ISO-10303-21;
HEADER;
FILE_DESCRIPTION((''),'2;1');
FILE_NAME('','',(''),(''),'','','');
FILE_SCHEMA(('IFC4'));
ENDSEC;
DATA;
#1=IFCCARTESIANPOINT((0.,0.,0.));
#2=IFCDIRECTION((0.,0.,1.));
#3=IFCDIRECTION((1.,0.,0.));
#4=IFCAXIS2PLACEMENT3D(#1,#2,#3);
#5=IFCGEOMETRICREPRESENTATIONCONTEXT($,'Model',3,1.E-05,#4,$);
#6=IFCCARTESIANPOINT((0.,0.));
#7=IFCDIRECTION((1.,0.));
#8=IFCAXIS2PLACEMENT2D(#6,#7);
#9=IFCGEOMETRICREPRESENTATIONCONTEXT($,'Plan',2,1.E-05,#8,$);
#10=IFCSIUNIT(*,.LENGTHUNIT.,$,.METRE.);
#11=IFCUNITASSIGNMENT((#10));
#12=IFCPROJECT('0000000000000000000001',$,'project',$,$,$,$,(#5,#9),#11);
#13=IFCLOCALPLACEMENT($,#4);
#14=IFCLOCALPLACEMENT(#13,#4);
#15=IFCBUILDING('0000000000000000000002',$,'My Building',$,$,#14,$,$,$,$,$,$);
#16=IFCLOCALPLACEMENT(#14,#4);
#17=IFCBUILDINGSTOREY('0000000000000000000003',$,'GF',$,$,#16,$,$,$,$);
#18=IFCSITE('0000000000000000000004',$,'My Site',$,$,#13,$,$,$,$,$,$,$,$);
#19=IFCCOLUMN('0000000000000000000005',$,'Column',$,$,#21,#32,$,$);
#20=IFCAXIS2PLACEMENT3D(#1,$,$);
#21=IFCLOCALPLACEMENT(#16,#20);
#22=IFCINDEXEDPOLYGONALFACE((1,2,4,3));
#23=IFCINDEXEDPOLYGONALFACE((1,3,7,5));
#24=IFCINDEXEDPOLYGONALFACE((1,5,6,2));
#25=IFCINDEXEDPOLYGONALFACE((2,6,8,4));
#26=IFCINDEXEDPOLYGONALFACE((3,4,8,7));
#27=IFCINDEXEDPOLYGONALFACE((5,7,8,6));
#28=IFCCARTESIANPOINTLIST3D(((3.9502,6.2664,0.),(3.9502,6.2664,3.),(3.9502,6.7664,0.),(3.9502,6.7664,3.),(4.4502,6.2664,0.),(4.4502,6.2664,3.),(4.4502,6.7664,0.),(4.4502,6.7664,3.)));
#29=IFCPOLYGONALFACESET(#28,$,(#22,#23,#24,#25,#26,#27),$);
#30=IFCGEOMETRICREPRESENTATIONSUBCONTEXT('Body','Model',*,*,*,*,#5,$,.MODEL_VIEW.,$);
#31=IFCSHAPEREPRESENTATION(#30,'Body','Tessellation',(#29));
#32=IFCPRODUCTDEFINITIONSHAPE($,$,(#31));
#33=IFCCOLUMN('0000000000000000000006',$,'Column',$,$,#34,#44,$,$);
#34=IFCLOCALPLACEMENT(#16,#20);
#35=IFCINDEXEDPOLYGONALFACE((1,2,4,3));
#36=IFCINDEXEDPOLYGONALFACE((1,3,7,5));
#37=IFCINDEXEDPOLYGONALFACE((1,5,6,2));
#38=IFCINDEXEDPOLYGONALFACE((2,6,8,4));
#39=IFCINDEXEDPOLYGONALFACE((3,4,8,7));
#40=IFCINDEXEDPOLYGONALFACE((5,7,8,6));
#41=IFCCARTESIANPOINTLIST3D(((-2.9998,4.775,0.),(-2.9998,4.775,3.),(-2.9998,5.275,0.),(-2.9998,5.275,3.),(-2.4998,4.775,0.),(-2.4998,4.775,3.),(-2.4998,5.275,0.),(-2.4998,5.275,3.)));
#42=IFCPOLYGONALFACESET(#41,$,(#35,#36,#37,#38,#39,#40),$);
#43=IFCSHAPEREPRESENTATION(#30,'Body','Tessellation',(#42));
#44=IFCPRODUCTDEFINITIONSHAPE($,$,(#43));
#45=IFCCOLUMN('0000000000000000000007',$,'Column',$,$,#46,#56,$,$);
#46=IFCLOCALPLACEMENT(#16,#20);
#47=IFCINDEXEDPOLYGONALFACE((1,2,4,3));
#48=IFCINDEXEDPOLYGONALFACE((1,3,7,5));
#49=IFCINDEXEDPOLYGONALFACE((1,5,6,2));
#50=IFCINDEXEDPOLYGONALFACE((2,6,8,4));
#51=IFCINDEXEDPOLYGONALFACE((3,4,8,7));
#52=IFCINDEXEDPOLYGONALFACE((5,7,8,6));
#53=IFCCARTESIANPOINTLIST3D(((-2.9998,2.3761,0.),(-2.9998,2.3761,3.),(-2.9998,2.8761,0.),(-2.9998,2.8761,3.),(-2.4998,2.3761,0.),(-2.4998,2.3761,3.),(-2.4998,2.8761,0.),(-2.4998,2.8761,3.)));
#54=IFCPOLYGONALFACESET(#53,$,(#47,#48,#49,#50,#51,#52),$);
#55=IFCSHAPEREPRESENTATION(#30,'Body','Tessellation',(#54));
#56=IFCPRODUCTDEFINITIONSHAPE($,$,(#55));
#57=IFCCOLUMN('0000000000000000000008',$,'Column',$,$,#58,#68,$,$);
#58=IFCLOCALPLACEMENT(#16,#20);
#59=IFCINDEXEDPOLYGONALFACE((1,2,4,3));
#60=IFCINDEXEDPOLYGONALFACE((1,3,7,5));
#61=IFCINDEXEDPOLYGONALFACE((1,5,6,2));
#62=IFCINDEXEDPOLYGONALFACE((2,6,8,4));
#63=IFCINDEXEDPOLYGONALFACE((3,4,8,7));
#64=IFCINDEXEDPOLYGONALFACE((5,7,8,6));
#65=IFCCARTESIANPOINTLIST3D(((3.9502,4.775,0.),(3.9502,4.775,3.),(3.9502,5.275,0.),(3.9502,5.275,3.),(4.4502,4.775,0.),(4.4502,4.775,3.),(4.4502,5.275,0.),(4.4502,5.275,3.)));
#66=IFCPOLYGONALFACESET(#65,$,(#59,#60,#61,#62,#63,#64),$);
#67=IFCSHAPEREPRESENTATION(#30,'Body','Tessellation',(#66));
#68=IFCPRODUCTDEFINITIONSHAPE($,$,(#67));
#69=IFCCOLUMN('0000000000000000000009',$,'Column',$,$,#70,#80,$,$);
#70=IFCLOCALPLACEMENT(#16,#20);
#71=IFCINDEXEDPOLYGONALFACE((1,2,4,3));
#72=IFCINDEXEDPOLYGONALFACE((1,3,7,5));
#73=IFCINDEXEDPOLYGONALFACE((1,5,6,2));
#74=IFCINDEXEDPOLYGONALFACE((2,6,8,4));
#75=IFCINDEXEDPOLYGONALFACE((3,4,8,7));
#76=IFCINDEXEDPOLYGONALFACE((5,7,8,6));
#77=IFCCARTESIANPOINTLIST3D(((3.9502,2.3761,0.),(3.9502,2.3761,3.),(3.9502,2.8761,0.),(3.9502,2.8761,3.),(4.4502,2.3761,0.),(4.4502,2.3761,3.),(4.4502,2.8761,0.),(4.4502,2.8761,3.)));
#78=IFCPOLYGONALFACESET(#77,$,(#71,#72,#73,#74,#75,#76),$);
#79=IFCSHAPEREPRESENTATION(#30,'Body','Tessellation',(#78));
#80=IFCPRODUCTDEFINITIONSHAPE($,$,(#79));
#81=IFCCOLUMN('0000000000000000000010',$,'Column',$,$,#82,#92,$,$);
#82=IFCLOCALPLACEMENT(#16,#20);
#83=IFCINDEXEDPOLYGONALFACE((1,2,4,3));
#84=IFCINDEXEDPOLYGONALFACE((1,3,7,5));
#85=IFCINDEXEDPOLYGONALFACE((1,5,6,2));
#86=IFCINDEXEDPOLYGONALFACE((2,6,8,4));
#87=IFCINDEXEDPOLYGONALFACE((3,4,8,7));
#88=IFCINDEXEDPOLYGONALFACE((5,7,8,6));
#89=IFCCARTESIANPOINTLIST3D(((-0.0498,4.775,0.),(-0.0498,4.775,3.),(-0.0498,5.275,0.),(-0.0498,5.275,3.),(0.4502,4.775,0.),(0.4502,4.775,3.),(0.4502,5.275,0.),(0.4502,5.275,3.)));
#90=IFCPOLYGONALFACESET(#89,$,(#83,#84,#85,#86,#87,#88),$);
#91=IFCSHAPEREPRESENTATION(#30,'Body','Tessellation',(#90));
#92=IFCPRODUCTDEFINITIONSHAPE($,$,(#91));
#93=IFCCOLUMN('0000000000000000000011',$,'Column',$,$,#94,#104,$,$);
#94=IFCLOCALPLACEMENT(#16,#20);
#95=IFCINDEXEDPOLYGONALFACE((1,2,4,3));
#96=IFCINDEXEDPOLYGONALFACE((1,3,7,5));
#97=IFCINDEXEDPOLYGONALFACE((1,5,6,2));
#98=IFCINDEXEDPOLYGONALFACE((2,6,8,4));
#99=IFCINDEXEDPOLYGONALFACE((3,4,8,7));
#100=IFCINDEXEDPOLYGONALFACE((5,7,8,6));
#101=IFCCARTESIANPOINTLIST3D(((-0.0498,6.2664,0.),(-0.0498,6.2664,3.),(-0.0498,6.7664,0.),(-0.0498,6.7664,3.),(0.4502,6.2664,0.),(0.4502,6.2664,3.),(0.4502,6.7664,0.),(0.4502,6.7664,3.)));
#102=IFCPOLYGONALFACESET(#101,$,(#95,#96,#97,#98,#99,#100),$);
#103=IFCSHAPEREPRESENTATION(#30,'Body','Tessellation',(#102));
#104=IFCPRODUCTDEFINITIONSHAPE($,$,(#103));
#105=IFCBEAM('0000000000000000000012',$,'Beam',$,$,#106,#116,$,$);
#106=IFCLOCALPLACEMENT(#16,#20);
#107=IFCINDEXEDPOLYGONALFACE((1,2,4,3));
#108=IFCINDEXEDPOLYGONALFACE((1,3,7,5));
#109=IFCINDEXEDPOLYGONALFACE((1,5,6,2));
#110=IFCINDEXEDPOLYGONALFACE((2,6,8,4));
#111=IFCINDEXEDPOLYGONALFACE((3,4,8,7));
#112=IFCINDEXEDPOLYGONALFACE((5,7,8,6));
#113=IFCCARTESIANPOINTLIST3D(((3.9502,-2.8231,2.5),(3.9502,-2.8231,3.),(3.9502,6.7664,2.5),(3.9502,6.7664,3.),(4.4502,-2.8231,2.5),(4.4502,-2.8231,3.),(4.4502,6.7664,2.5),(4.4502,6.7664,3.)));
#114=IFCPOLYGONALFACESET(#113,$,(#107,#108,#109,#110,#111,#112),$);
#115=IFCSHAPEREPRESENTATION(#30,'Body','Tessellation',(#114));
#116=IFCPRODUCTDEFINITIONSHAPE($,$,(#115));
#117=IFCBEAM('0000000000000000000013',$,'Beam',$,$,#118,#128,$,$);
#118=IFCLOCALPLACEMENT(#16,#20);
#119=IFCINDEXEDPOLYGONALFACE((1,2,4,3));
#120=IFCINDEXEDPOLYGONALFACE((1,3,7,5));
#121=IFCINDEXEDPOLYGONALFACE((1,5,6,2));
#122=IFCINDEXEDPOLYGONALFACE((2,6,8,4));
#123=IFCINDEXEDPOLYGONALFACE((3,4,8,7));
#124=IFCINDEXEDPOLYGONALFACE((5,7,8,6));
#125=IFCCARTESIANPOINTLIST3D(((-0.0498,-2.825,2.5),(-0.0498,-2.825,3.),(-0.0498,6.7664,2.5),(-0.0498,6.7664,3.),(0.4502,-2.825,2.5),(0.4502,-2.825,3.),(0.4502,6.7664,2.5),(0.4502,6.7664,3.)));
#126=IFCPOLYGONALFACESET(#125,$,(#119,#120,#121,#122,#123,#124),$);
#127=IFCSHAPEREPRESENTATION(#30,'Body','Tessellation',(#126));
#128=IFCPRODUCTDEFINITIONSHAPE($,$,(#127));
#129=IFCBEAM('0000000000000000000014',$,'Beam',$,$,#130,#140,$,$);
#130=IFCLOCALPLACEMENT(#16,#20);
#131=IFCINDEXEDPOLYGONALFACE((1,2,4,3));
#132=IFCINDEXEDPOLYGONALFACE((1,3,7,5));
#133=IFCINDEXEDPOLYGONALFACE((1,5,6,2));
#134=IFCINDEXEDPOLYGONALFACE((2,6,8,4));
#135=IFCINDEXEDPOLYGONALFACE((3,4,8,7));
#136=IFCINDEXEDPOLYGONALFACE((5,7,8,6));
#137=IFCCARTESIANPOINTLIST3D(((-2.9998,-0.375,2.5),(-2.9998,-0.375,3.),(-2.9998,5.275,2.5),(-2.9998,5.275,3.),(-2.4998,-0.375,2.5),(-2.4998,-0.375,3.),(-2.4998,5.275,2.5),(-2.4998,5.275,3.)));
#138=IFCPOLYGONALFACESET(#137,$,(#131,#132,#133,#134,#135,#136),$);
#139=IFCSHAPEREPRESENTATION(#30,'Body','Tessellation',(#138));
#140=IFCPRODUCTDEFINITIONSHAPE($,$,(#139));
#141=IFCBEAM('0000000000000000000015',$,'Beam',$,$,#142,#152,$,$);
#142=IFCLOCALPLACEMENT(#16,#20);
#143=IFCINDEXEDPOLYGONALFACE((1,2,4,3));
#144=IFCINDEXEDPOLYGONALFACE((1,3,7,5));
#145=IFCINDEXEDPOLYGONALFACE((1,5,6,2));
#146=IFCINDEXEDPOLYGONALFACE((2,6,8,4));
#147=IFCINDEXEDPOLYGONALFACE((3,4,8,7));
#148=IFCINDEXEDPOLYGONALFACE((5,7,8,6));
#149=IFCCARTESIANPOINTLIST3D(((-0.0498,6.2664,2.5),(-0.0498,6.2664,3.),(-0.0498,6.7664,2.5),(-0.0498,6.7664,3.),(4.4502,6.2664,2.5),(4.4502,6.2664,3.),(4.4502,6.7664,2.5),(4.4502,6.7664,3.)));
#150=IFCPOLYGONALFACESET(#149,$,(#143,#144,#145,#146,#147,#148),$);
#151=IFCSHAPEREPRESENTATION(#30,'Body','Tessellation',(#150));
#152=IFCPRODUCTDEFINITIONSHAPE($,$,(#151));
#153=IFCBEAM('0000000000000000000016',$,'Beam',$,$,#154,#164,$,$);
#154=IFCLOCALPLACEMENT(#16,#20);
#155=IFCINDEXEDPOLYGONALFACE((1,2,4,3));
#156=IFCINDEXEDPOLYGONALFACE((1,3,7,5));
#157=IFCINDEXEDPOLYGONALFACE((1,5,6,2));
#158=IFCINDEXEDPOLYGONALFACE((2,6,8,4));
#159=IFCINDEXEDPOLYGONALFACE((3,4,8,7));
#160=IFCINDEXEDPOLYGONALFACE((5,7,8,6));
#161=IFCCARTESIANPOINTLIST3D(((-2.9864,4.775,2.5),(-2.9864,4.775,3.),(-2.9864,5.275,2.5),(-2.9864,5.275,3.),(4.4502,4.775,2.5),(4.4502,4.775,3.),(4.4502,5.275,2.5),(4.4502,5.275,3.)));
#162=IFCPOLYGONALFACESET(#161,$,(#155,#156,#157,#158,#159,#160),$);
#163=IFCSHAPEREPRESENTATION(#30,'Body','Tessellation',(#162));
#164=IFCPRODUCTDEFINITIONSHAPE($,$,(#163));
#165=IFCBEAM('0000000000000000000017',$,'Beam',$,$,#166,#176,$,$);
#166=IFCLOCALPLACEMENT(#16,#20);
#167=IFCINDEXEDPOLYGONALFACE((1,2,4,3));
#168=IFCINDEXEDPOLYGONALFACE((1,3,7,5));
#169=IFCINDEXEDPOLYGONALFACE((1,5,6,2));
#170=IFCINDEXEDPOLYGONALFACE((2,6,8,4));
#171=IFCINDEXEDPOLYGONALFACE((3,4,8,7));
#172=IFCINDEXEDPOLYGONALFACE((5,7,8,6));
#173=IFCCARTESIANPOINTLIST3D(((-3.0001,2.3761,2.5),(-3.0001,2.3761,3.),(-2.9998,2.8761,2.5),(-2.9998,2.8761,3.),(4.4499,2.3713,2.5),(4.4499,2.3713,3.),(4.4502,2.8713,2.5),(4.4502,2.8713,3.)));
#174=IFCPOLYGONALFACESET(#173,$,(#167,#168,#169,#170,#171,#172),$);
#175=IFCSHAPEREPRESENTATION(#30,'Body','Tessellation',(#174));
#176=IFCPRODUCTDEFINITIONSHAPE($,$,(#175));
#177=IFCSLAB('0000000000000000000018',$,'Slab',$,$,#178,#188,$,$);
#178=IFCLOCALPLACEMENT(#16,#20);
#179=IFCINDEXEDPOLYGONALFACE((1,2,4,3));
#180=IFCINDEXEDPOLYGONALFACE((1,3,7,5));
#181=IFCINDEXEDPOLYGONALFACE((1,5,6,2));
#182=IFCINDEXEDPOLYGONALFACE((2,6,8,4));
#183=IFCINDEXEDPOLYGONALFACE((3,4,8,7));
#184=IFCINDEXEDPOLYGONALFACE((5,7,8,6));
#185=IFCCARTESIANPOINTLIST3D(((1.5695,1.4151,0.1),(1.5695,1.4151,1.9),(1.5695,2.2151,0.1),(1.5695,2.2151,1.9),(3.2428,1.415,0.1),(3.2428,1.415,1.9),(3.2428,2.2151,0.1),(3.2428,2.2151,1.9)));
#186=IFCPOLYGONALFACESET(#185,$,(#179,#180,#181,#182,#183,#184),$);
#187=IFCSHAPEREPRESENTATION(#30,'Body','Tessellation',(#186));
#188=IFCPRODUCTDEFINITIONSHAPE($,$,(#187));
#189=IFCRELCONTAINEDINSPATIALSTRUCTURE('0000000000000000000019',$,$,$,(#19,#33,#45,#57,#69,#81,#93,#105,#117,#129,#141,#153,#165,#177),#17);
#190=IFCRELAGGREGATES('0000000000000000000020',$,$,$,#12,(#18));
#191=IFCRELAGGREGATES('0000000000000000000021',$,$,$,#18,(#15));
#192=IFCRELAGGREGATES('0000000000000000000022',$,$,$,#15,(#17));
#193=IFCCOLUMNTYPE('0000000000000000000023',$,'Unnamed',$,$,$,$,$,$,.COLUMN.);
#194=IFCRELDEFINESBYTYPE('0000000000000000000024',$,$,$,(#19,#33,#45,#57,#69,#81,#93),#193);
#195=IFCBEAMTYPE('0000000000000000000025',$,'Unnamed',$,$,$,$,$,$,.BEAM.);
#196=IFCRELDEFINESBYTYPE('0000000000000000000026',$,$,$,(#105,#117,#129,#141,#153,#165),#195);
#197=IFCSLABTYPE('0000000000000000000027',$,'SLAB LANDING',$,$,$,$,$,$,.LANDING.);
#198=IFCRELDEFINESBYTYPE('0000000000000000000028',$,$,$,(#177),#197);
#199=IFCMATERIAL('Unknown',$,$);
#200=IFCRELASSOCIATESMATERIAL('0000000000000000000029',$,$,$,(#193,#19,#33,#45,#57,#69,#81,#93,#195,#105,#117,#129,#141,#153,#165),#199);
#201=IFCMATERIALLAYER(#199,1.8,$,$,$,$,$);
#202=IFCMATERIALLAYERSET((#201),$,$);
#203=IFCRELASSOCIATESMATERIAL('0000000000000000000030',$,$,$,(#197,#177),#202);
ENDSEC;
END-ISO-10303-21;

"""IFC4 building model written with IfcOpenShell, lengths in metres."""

from ifc_helpers import new_model, si_unit, frame, origin_with_axes, origin_2d_with_axis, place, context, subcontext, project, spatial, indexed_curve, rectangle, outline, extrude, material, layer, layer_set, layer_usage, material_profile, profile_set, profile_usage, type_object, element, save


model = new_model("IFC4")

# Units and contexts
model_context = context("Model", 3, precision=1e-05, world=origin_with_axes())
plan_context = context("Plan", 2, precision=1e-05, world=origin_2d_with_axis())
body_context_1 = subcontext(model_context, "Body", "Model", "MODEL_VIEW")
ifc_project = project(units=[si_unit("LENGTHUNIT", "METRE")], contexts=[model_context, plan_context])

# Site, building, storey
site_placement = place(None, origin_with_axes())
site = spatial("IfcSite", under=ifc_project, at=site_placement, Name="My Site")
building_placement = place(site_placement, origin_with_axes())
building = spatial("IfcBuilding", under=site, at=building_placement, Name="My Building")
storey_placement = place(building_placement, origin_with_axes())
storey = spatial("IfcBuildingStorey", under=building, at=storey_placement, Name="GF")

# Columns
ifc_material_1 = material(Name="Unknown")
ifc_material_profile_1 = material_profile(ifc_material_1, rectangle(XDim=0.5, YDim=0.5))
ifc_profile_set_1 = profile_set([ifc_material_profile_1])
ifc_profile_usage_1 = profile_usage(ifc_profile_set_1, cardinal=5)
column_type = type_object("IfcColumnType", Name="Unnamed", PredefinedType="COLUMN", material=ifc_profile_set_1)
column_1_placement = place(storey_placement, frame((4.2002, 6.5164, 0.0), z_axis=(0.0, 0.0, 1.0), x_axis=(1.0, 0.0, 0.0)))
element("IfcColumn", 1, at=column_1_placement, inside=storey, type_object=column_type, material=ifc_profile_usage_1, Name="Column", context=body_context_1, shape_type="SweptSolid", body=[
    extrude(rectangle(XDim=0.5, YDim=0.5), origin_with_axes(), (0.0, 0.0, 1.0), 3.0),
])
ifc_profile_usage_2 = profile_usage(ifc_profile_set_1, cardinal=5)
column_2_placement = place(storey_placement, frame((-2.7498, 5.025, 0.0), z_axis=(0.0, 0.0, 1.0), x_axis=(1.0, 0.0, 0.0)))
element("IfcColumn", 2, at=column_2_placement, inside=storey, type_object=column_type, material=ifc_profile_usage_2, Name="Column", context=body_context_1, shape_type="SweptSolid", body=[
    extrude(rectangle(XDim=0.5, YDim=0.5), origin_with_axes(), (0.0, 0.0, 1.0), 3.0),
])
ifc_profile_usage_3 = profile_usage(ifc_profile_set_1, cardinal=5)
column_3_placement = place(storey_placement, frame((-2.7498, 2.6261, 0.0), z_axis=(0.0, 0.0, 1.0), x_axis=(1.0, 0.0, 0.0)))
element("IfcColumn", 3, at=column_3_placement, inside=storey, type_object=column_type, material=ifc_profile_usage_3, Name="Column", context=body_context_1, shape_type="SweptSolid", body=[
    extrude(rectangle(XDim=0.5, YDim=0.5), origin_with_axes(), (0.0, 0.0, 1.0), 3.0),
])
ifc_profile_usage_4 = profile_usage(ifc_profile_set_1, cardinal=5)
column_4_placement = place(storey_placement, frame((4.2002, 5.025, 0.0), z_axis=(0.0, 0.0, 1.0), x_axis=(1.0, 0.0, 0.0)))
element("IfcColumn", 4, at=column_4_placement, inside=storey, type_object=column_type, material=ifc_profile_usage_4, Name="Column", context=body_context_1, shape_type="SweptSolid", body=[
    extrude(rectangle(XDim=0.5, YDim=0.5), origin_with_axes(), (0.0, 0.0, 1.0), 3.0),
])
ifc_profile_usage_5 = profile_usage(ifc_profile_set_1, cardinal=5)
column_5_placement = place(storey_placement, frame((4.2002, 2.6261, 0.0), z_axis=(0.0, 0.0, 1.0), x_axis=(1.0, 0.0, 0.0)))
element("IfcColumn", 5, at=column_5_placement, inside=storey, type_object=column_type, material=ifc_profile_usage_5, Name="Column", context=body_context_1, shape_type="SweptSolid", body=[
    extrude(rectangle(XDim=0.5, YDim=0.5), origin_with_axes(), (0.0, 0.0, 1.0), 3.0),
])
ifc_profile_usage_6 = profile_usage(ifc_profile_set_1, cardinal=5)
column_6_placement = place(storey_placement, frame((0.2002, 5.025, 0.0), z_axis=(0.0, 0.0, 1.0), x_axis=(1.0, 0.0, 0.0)))
element("IfcColumn", 6, at=column_6_placement, inside=storey, type_object=column_type, material=ifc_profile_usage_6, Name="Column", context=body_context_1, shape_type="SweptSolid", body=[
    extrude(rectangle(XDim=0.5, YDim=0.5), origin_with_axes(), (0.0, 0.0, 1.0), 3.0),
])
ifc_profile_usage_7 = profile_usage(ifc_profile_set_1, cardinal=5)
column_7_placement = place(storey_placement, frame((0.2002, 6.5164, 0.0), z_axis=(0.0, 0.0, 1.0), x_axis=(1.0, 0.0, 0.0)))
element("IfcColumn", 7, at=column_7_placement, inside=storey, type_object=column_type, material=ifc_profile_usage_7, Name="Column", context=body_context_1, shape_type="SweptSolid", body=[
    extrude(rectangle(XDim=0.5, YDim=0.5), origin_with_axes(), (0.0, 0.0, 1.0), 3.0),
])

# Beams
ifc_material_profile_2 = material_profile(ifc_material_1, rectangle(XDim=0.5, YDim=0.5))
ifc_profile_set_2 = profile_set([ifc_material_profile_2])
ifc_profile_usage_8 = profile_usage(ifc_profile_set_2, cardinal=7)
beam_type = type_object("IfcBeamType", Name="Unnamed", PredefinedType="BEAM", material=ifc_profile_set_2)
beam_1_placement = place(storey_placement, frame((4.4502, 6.7664, 3.0), z_axis=(0.0, -1.0, 0.0), x_axis=(1.0, 0.0, 0.0)))
element("IfcBeam", 8, at=beam_1_placement, inside=storey, type_object=beam_type, material=ifc_profile_usage_8, Name="Beam", context=body_context_1, shape_type="SweptSolid", body=[
    extrude(rectangle(XDim=0.5, YDim=0.5), frame((-0.25, -0.25, 0.0), z_axis=(0.0, 0.0, 1.0), x_axis=(1.0, 0.0, 0.0)), (0.0, 0.0, 1.0), 9.5895),
])
ifc_profile_usage_9 = profile_usage(ifc_profile_set_2, cardinal=7)
beam_2_placement = place(storey_placement, frame((0.4502, 6.7664, 3.0), z_axis=(0.0, -1.0, 0.0), x_axis=(1.0, 0.0, 0.0)))
element("IfcBeam", 9, at=beam_2_placement, inside=storey, type_object=beam_type, material=ifc_profile_usage_9, Name="Beam", context=body_context_1, shape_type="SweptSolid", body=[
    extrude(rectangle(XDim=0.5, YDim=0.5), frame((-0.25, -0.25, 0.0), z_axis=(0.0, 0.0, 1.0), x_axis=(1.0, 0.0, 0.0)), (0.0, 0.0, 1.0), 9.5914),
])
ifc_profile_usage_10 = profile_usage(ifc_profile_set_2, cardinal=7)
beam_3_placement = place(storey_placement, frame((-2.4998, 5.275, 3.0), z_axis=(0.0, -1.0, 0.0), x_axis=(1.0, 0.0, 0.0)))
element("IfcBeam", 10, at=beam_3_placement, inside=storey, type_object=beam_type, material=ifc_profile_usage_10, Name="Beam", context=body_context_1, shape_type="SweptSolid", body=[
    extrude(rectangle(XDim=0.5, YDim=0.5), frame((-0.25, -0.25, 0.0), z_axis=(0.0, 0.0, 1.0), x_axis=(1.0, 0.0, 0.0)), (0.0, 0.0, 1.0), 5.65),
])
ifc_profile_usage_11 = profile_usage(ifc_profile_set_2, cardinal=7)
beam_4_placement = place(storey_placement, frame((4.4502, 6.2664, 3.0), z_axis=(-1.0, -0.000001, 0.000001), x_axis=(0.000001, -1.0, 0.0)))
element("IfcBeam", 11, at=beam_4_placement, inside=storey, type_object=beam_type, material=ifc_profile_usage_11, Name="Beam", context=body_context_1, shape_type="SweptSolid", body=[
    extrude(rectangle(XDim=0.5, YDim=0.5), frame((-0.25, -0.25, 0.0), z_axis=(0.0, 0.0, 1.0), x_axis=(1.0, 0.0, 0.0)), (0.0, 0.0, 1.0), 4.5),
])
ifc_profile_usage_12 = profile_usage(ifc_profile_set_2, cardinal=7)
beam_5_placement = place(storey_placement, frame((-2.9864, 5.275, 3.0), z_axis=(1.0, -0.000001, 0.000001), x_axis=(0.000001, 1.0, 0.0)))
element("IfcBeam", 12, at=beam_5_placement, inside=storey, type_object=beam_type, material=ifc_profile_usage_12, Name="Beam", context=body_context_1, shape_type="SweptSolid", body=[
    extrude(rectangle(XDim=0.5, YDim=0.5), frame((-0.25, -0.25, 0.0), z_axis=(0.0, 0.0, 1.0), x_axis=(1.0, 0.0, 0.0)), (0.0, 0.0, 1.0), 7.4366),
])
ifc_profile_usage_13 = profile_usage(ifc_profile_set_2, cardinal=7)
beam_6_placement = place(storey_placement, frame((-2.9998, 2.8761, 3.0), z_axis=(1.0, -0.000643, 0.0), x_axis=(0.000643, 1.0, 0.0)))
element("IfcBeam", 13, at=beam_6_placement, inside=storey, type_object=beam_type, material=ifc_profile_usage_13, Name="Beam", context=body_context_1, shape_type="SweptSolid", body=[
    extrude(rectangle(XDim=0.5, YDim=0.5), frame((-0.25, -0.25, 0.0), z_axis=(0.0, 0.0, 1.0), x_axis=(1.0, 0.0, 0.0)), (0.0, 0.0, 1.0), 7.45),
])

# Slab
ifc_layer_1 = layer(ifc_material_1, 1.8)
ifc_layer_set_1 = layer_set([ifc_layer_1])
ifc_layer_usage_1 = layer_usage(ifc_layer_set_1, "AXIS3", "POSITIVE", -1.8)
slab_type = type_object("IfcSlabType", Name="SLAB LANDING", PredefinedType="LANDING", material=ifc_layer_set_1)
slab_placement = place(storey_placement, frame((1.5695, 2.2151, 1.9), z_axis=(0.0, 0.0, 1.0), x_axis=(1.0, 0.0, 0.0)))
element("IfcSlab", 14, at=slab_placement, inside=storey, type_object=slab_type, material=ifc_layer_usage_1, Name="Slab", context=body_context_1, shape_type="SweptSolid", body=[
    extrude(outline(indexed_curve([(0.0, 0.0), (1.6733, 0.0), (1.6733, -0.8), (0.0, -0.8), (0.0, 0.0)])), frame((0.0, 0.0, -1.8), z_axis=(0.0, 0.0, 1.0), x_axis=(1.0, 0.0, 0.0)), (0.0, 0.0, 1.0), 1.8),
])

save(model, "model.ifc")
